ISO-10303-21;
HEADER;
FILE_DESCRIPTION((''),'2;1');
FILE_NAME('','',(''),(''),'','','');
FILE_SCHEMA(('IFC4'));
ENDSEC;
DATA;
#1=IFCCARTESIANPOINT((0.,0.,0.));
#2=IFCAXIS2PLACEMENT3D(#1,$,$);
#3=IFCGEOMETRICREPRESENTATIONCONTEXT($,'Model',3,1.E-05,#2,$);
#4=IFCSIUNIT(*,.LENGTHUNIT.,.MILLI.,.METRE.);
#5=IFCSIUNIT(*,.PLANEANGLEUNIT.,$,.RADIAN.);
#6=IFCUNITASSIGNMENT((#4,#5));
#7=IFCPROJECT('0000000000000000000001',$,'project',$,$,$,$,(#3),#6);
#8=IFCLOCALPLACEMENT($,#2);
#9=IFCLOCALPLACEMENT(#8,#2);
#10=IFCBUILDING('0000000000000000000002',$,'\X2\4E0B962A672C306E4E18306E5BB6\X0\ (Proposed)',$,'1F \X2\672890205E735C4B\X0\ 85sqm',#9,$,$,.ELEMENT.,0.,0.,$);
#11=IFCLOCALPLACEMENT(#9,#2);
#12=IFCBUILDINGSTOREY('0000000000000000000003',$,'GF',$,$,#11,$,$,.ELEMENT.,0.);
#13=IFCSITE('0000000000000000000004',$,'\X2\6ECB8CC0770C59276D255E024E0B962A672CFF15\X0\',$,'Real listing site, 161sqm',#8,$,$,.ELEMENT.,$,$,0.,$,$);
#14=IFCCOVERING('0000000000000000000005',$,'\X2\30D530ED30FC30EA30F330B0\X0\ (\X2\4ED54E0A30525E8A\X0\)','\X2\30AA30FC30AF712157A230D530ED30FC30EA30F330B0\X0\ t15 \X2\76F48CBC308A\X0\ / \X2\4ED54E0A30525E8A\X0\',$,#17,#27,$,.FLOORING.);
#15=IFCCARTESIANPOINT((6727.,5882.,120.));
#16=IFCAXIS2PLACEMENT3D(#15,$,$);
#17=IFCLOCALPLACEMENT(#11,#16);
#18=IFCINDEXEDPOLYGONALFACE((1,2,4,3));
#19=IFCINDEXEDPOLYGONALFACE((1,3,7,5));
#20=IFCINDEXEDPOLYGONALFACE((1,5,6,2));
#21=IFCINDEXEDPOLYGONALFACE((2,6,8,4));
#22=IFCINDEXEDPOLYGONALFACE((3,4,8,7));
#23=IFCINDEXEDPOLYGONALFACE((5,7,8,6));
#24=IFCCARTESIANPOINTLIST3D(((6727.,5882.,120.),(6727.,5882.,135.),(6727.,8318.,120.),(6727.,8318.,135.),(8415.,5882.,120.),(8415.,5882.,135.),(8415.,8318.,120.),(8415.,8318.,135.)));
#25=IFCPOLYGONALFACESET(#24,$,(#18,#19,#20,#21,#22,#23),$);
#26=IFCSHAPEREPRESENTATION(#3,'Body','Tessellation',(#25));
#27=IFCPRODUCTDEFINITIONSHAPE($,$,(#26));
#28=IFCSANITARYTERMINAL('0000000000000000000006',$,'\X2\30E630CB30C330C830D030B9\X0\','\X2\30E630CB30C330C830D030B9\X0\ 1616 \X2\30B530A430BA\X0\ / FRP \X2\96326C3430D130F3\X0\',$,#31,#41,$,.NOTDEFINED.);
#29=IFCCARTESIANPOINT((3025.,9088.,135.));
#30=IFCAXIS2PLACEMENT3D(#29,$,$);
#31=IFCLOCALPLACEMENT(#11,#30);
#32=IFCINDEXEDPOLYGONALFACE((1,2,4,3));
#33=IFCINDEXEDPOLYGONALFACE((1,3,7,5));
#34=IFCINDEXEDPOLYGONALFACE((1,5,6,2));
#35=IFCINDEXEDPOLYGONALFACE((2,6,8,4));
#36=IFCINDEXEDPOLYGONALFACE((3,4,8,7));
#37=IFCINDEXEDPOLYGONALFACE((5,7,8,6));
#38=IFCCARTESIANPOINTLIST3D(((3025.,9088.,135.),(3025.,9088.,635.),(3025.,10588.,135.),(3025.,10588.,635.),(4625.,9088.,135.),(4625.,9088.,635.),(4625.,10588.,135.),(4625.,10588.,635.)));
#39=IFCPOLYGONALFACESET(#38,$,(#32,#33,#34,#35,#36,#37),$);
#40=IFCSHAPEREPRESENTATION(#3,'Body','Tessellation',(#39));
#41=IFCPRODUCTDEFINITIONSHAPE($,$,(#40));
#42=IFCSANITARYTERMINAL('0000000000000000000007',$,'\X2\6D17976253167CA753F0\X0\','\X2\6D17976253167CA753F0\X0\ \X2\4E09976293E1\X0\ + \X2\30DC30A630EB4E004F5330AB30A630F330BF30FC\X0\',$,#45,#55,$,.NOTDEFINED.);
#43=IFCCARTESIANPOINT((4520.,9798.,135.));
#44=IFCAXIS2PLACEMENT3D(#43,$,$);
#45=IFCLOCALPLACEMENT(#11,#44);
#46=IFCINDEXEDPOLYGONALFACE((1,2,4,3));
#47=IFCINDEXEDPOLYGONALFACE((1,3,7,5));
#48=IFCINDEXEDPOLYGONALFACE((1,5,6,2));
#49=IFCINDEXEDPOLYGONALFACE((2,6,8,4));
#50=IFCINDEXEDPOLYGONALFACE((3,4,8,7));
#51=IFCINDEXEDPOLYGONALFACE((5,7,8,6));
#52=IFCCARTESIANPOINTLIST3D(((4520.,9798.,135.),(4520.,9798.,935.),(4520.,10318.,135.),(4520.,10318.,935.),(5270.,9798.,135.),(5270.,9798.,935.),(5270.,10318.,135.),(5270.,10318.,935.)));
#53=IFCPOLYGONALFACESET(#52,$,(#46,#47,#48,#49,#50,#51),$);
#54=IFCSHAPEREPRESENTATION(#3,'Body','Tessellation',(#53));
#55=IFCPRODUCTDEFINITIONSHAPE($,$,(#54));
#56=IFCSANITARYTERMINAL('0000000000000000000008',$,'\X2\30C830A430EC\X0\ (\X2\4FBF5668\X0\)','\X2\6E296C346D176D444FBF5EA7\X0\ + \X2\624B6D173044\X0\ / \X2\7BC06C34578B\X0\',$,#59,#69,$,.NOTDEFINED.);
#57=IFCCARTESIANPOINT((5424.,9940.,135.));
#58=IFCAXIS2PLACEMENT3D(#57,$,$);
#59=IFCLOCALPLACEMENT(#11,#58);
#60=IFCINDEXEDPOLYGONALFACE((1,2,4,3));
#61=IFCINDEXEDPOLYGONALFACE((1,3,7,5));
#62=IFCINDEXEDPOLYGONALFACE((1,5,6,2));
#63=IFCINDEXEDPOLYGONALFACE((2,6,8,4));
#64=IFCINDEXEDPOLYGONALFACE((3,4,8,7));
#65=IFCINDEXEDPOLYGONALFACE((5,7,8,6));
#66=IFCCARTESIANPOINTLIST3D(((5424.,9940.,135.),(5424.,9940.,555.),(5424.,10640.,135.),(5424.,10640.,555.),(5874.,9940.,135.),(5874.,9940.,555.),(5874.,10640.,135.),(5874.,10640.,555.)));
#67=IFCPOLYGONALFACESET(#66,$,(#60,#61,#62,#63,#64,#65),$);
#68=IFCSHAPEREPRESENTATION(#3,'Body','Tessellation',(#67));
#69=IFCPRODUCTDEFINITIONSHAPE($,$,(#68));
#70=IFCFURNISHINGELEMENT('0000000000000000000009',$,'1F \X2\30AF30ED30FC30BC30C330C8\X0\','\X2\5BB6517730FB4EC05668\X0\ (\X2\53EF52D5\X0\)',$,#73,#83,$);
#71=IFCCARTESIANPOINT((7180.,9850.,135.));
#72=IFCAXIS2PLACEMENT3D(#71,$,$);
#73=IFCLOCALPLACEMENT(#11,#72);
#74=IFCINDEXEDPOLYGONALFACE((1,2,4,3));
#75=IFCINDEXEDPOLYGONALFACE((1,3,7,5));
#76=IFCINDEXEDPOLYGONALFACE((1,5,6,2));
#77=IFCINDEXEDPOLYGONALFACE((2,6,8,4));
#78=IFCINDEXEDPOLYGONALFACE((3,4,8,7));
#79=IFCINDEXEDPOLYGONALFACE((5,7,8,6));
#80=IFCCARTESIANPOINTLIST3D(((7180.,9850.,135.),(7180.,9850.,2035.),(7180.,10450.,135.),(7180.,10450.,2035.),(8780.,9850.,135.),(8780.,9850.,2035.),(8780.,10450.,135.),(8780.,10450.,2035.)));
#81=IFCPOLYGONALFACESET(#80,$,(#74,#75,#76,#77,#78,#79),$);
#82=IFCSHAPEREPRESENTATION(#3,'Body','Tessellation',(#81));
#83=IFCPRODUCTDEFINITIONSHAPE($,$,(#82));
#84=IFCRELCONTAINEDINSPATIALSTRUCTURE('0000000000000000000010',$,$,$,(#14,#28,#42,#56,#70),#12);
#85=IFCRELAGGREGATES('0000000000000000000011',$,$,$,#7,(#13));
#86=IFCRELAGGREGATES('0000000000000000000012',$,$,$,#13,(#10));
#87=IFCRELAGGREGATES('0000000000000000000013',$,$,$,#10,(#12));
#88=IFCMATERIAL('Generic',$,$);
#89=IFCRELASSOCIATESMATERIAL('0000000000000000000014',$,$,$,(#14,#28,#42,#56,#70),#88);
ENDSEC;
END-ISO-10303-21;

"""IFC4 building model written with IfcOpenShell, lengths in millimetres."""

from ifc_helpers import new_model, si_unit, frame, frame_2d, origin, place, context, project, spatial, rectangle, extrude, material, element, save


model = new_model("IFC4")

# Units and contexts
model_context = context("Model", 3, precision=1e-05, world=origin())
ifc_project = project(units=[si_unit("LENGTHUNIT", "METRE", prefix="MILLI"), si_unit("PLANEANGLEUNIT", "RADIAN")], contexts=[model_context])

# Site, building, storey
site_placement = place(None, origin())
site = spatial("IfcSite", under=ifc_project, at=site_placement, Name="滋賀県大津市下阪本５", ObjectType="Real listing site, 161sqm", CompositionType="ELEMENT", RefElevation=0.0)
building_placement = place(site_placement, origin())
building = spatial("IfcBuilding", under=site, at=building_placement, Name="下阪本の丘の家 (Proposed)", ObjectType="1F 木造平屋 85sqm", CompositionType="ELEMENT", ElevationOfRefHeight=0.0, ElevationOfTerrain=0.0)
storey_placement = place(building_placement, origin())
storey = spatial("IfcBuildingStorey", under=building, at=storey_placement, Name="GF", CompositionType="ELEMENT", Elevation=0.0)

# Covering
ifc_material_1 = material(Name="Generic")
covering_1_placement = place(storey_placement, frame((6727.0, 5882.0, 120.0)))
element("IfcCovering", 1, at=covering_1_placement, inside=storey, material=ifc_material_1, Name="フローリング (仕上げ床)", Description="オーク無垢フローリング t15 直貼り / 仕上げ床", PredefinedType="FLOORING", context=model_context, shape_type="SweptSolid", body=[
    extrude(rectangle(XDim=1688.0, YDim=2436.0, at=frame_2d((844.0, 1218.0))), frame((6727.0, 5882.0, 120.0)), (0.0, 0.0, 1.0), 15.0),
])

# Sanitary terminals
sanitary_terminal_1_placement = place(storey_placement, frame((3025.0, 9088.0, 135.0)))
element("IfcSanitaryTerminal", 2, at=sanitary_terminal_1_placement, inside=storey, material=ifc_material_1, Name="ユニットバス", Description="ユニットバス 1616 サイズ / FRP 防水パン", PredefinedType="NOTDEFINED", context=model_context, shape_type="SweptSolid", body=[
    extrude(rectangle(XDim=1600.0, YDim=1500.0, at=frame_2d((800.0, 750.0))), frame((3025.0, 9088.0, 135.0)), (0.0, 0.0, 1.0), 500.0),
])
sanitary_terminal_2_placement = place(storey_placement, frame((4520.0, 9798.0, 135.0)))
element("IfcSanitaryTerminal", 3, at=sanitary_terminal_2_placement, inside=storey, material=ifc_material_1, Name="洗面化粧台", Description="洗面化粧台 三面鏡 + ボウル一体カウンター", PredefinedType="NOTDEFINED", context=model_context, shape_type="SweptSolid", body=[
    extrude(rectangle(XDim=750.0, YDim=520.0, at=frame_2d((375.0, 260.0))), frame((4520.0, 9798.0, 135.0)), (0.0, 0.0, 1.0), 800.0),
])
sanitary_terminal_3_placement = place(storey_placement, frame((5424.0, 9940.0, 135.0)))
element("IfcSanitaryTerminal", 4, at=sanitary_terminal_3_placement, inside=storey, material=ifc_material_1, Name="トイレ (便器)", Description="温水洗浄便座 + 手洗い / 節水型", PredefinedType="NOTDEFINED", context=model_context, shape_type="SweptSolid", body=[
    extrude(rectangle(XDim=450.0, YDim=700.0, at=frame_2d((225.0, 350.0))), frame((5424.0, 9940.0, 135.0)), (0.0, 0.0, 1.0), 420.0),
])

# Furnishing element
furnishing_placement = place(storey_placement, frame((7180.0, 9850.0, 135.0)))
element("IfcFurnishingElement", 5, at=furnishing_placement, inside=storey, material=ifc_material_1, Name="1F クローゼット", Description="家具・什器 (可動)", context=model_context, shape_type="SweptSolid", body=[
    extrude(rectangle(XDim=1600.0, YDim=600.0, at=frame_2d((800.0, 300.0))), frame((7180.0, 9850.0, 135.0)), (0.0, 0.0, 1.0), 1900.0),
])

save(model, "model.ifc")
